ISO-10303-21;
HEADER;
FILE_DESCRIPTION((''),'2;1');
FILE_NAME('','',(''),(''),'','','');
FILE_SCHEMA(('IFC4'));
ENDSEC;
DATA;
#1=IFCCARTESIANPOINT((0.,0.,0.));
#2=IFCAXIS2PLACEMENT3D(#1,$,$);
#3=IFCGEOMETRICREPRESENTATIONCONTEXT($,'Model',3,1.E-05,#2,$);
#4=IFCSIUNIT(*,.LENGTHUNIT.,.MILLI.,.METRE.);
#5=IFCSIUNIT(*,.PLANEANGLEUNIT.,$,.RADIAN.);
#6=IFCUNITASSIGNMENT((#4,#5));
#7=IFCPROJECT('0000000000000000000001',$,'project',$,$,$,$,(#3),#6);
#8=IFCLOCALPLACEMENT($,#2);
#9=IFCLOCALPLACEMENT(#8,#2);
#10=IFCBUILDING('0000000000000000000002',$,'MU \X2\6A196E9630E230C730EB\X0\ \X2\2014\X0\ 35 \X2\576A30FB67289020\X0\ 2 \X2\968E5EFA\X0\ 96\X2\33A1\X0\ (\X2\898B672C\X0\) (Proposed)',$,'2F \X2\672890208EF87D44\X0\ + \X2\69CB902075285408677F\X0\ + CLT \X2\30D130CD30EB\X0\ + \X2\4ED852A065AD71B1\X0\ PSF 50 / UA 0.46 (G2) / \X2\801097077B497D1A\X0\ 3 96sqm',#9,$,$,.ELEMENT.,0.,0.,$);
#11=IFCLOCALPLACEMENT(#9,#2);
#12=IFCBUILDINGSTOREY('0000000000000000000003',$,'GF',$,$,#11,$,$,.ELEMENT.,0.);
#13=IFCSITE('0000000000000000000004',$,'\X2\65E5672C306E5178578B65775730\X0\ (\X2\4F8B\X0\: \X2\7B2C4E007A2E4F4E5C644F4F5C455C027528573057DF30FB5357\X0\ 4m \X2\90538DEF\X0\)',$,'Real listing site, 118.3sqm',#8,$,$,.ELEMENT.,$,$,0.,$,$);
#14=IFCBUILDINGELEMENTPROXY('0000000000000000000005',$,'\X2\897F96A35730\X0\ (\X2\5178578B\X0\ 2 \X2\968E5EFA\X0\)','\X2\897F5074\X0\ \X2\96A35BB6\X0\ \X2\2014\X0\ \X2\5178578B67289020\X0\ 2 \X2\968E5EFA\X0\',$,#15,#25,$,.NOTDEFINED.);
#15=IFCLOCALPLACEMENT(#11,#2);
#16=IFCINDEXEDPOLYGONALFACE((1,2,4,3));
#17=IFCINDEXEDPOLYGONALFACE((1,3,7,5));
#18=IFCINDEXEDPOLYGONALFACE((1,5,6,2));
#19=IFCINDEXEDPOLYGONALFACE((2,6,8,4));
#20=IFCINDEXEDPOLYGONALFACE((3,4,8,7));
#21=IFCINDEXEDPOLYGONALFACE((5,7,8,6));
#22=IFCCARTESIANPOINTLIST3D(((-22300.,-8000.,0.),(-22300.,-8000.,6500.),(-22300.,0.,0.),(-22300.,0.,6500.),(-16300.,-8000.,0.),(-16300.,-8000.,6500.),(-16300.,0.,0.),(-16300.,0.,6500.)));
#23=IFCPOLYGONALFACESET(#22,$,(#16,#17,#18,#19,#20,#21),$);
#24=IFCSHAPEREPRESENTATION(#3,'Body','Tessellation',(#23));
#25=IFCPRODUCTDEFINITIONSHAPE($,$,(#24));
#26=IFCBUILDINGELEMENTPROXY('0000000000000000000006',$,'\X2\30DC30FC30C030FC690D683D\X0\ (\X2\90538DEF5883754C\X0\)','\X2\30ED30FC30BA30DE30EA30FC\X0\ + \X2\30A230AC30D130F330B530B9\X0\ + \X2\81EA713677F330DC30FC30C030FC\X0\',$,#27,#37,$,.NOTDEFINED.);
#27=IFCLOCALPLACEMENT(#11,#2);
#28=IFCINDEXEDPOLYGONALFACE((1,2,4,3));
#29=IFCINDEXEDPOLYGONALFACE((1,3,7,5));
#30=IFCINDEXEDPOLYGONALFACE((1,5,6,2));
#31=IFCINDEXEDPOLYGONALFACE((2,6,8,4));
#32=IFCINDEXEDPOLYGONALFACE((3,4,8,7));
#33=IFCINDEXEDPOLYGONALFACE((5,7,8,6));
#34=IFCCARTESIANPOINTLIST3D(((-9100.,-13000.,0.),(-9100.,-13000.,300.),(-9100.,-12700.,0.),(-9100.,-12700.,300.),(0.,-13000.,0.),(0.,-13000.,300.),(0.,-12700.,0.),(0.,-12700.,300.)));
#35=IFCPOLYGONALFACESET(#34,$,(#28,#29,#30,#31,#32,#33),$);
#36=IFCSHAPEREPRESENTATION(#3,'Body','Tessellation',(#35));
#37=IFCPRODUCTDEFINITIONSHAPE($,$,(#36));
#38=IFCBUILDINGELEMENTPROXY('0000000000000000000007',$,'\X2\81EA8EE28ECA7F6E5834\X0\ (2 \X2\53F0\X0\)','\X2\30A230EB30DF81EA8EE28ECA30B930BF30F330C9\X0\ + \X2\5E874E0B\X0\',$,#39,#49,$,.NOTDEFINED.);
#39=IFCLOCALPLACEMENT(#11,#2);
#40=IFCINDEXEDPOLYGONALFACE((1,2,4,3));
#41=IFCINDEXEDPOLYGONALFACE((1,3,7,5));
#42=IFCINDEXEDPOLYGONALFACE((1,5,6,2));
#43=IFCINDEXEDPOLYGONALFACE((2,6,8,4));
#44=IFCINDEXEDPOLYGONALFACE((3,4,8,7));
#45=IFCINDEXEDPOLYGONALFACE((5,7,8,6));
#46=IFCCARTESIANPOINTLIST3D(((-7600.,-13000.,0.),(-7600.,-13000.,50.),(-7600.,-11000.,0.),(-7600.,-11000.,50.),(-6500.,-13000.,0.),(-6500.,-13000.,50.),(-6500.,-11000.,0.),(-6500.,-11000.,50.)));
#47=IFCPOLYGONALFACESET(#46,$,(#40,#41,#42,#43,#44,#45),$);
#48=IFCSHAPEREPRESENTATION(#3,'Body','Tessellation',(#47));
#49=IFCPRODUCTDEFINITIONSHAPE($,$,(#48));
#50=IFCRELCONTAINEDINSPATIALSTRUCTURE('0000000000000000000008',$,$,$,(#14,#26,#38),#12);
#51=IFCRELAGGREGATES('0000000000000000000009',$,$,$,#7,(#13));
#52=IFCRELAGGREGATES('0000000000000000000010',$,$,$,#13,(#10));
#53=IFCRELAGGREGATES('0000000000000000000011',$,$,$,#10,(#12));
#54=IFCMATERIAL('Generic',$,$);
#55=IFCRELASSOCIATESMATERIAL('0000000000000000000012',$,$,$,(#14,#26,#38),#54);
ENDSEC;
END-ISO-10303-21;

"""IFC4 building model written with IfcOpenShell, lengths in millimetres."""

from ifc_helpers import new_model, si_unit, frame, frame_2d, origin, place, context, project, spatial, rectangle, extrude, material, element, save


model = new_model("IFC4")

# Units and contexts
model_context = context("Model", 3, precision=1e-05, world=origin())
ifc_project = project(units=[si_unit("LENGTHUNIT", "METRE", prefix="MILLI"), si_unit("PLANEANGLEUNIT", "RADIAN")], contexts=[model_context])

# Site, building, storey
site_placement = place(None, origin())
site = spatial("IfcSite", under=ifc_project, at=site_placement, Name="日本の典型敷地 (例: 第一種低層住居専用地域・南 4m 道路)", ObjectType="Real listing site, 118.3sqm", CompositionType="ELEMENT", RefElevation=0.0)
building_placement = place(site_placement, origin())
building = spatial("IfcBuilding", under=site, at=building_placement, Name="MU 標準モデル — 35 坪・木造 2 階建 96㎡ (見本) (Proposed)", ObjectType="2F 木造軸組 + 構造用合板 + CLT パネル + 付加断熱 PSF 50 / UA 0.46 (G2) / 耐震等級 3 96sqm", CompositionType="ELEMENT", ElevationOfRefHeight=0.0, ElevationOfTerrain=0.0)
storey_placement = place(building_placement, origin())
storey = spatial("IfcBuildingStorey", under=building, at=storey_placement, Name="GF", CompositionType="ELEMENT", Elevation=0.0)

# Shared definitions
ifc_material_1 = material(Name="Generic")

# Building element proxies
proxy_1_placement = place(storey_placement, frame((-11150.0, -4000.0, 0.0)))
element("IfcBuildingElementProxy", 1, at=proxy_1_placement, inside=storey, material=ifc_material_1, Name="西隣地 (典型 2 階建)", Description="西側 隣家 — 典型木造 2 階建", PredefinedType="NOTDEFINED", context=model_context, shape_type="SweptSolid", body=[
    extrude(rectangle(XDim=6000.0, YDim=8000.0, at=frame_2d((3000.0, 4000.0))), frame((-11150.0, -4000.0, 0.0)), (0.0, 0.0, 1.0), 6500.0),
])
proxy_2_placement = place(storey_placement, frame((-4550.0, -6500.0, 0.0)))
element("IfcBuildingElementProxy", 2, at=proxy_2_placement, inside=storey, material=ifc_material_1, Name="ボーダー植栽 (道路境界)", Description="ローズマリー + アガパンサス + 自然石ボーダー", PredefinedType="NOTDEFINED", context=model_context, shape_type="SweptSolid", body=[
    extrude(rectangle(XDim=9100.0, YDim=300.0, at=frame_2d((4550.0, 150.0))), frame((-4550.0, -6500.0, 0.0)), (0.0, 0.0, 1.0), 300.0),
])
proxy_3_placement = place(storey_placement, frame((-3800.0, -6500.0, 0.0)))
element("IfcBuildingElementProxy", 3, at=proxy_3_placement, inside=storey, material=ifc_material_1, Name="自転車置場 (2 台)", Description="アルミ自転車スタンド + 庇下", PredefinedType="NOTDEFINED", context=model_context, shape_type="SweptSolid", body=[
    extrude(rectangle(XDim=1100.0, YDim=2000.0, at=frame_2d((550.0, 1000.0))), frame((-3800.0, -6500.0, 0.0)), (0.0, 0.0, 1.0), 50.0),
])

save(model, "model.ifc")
